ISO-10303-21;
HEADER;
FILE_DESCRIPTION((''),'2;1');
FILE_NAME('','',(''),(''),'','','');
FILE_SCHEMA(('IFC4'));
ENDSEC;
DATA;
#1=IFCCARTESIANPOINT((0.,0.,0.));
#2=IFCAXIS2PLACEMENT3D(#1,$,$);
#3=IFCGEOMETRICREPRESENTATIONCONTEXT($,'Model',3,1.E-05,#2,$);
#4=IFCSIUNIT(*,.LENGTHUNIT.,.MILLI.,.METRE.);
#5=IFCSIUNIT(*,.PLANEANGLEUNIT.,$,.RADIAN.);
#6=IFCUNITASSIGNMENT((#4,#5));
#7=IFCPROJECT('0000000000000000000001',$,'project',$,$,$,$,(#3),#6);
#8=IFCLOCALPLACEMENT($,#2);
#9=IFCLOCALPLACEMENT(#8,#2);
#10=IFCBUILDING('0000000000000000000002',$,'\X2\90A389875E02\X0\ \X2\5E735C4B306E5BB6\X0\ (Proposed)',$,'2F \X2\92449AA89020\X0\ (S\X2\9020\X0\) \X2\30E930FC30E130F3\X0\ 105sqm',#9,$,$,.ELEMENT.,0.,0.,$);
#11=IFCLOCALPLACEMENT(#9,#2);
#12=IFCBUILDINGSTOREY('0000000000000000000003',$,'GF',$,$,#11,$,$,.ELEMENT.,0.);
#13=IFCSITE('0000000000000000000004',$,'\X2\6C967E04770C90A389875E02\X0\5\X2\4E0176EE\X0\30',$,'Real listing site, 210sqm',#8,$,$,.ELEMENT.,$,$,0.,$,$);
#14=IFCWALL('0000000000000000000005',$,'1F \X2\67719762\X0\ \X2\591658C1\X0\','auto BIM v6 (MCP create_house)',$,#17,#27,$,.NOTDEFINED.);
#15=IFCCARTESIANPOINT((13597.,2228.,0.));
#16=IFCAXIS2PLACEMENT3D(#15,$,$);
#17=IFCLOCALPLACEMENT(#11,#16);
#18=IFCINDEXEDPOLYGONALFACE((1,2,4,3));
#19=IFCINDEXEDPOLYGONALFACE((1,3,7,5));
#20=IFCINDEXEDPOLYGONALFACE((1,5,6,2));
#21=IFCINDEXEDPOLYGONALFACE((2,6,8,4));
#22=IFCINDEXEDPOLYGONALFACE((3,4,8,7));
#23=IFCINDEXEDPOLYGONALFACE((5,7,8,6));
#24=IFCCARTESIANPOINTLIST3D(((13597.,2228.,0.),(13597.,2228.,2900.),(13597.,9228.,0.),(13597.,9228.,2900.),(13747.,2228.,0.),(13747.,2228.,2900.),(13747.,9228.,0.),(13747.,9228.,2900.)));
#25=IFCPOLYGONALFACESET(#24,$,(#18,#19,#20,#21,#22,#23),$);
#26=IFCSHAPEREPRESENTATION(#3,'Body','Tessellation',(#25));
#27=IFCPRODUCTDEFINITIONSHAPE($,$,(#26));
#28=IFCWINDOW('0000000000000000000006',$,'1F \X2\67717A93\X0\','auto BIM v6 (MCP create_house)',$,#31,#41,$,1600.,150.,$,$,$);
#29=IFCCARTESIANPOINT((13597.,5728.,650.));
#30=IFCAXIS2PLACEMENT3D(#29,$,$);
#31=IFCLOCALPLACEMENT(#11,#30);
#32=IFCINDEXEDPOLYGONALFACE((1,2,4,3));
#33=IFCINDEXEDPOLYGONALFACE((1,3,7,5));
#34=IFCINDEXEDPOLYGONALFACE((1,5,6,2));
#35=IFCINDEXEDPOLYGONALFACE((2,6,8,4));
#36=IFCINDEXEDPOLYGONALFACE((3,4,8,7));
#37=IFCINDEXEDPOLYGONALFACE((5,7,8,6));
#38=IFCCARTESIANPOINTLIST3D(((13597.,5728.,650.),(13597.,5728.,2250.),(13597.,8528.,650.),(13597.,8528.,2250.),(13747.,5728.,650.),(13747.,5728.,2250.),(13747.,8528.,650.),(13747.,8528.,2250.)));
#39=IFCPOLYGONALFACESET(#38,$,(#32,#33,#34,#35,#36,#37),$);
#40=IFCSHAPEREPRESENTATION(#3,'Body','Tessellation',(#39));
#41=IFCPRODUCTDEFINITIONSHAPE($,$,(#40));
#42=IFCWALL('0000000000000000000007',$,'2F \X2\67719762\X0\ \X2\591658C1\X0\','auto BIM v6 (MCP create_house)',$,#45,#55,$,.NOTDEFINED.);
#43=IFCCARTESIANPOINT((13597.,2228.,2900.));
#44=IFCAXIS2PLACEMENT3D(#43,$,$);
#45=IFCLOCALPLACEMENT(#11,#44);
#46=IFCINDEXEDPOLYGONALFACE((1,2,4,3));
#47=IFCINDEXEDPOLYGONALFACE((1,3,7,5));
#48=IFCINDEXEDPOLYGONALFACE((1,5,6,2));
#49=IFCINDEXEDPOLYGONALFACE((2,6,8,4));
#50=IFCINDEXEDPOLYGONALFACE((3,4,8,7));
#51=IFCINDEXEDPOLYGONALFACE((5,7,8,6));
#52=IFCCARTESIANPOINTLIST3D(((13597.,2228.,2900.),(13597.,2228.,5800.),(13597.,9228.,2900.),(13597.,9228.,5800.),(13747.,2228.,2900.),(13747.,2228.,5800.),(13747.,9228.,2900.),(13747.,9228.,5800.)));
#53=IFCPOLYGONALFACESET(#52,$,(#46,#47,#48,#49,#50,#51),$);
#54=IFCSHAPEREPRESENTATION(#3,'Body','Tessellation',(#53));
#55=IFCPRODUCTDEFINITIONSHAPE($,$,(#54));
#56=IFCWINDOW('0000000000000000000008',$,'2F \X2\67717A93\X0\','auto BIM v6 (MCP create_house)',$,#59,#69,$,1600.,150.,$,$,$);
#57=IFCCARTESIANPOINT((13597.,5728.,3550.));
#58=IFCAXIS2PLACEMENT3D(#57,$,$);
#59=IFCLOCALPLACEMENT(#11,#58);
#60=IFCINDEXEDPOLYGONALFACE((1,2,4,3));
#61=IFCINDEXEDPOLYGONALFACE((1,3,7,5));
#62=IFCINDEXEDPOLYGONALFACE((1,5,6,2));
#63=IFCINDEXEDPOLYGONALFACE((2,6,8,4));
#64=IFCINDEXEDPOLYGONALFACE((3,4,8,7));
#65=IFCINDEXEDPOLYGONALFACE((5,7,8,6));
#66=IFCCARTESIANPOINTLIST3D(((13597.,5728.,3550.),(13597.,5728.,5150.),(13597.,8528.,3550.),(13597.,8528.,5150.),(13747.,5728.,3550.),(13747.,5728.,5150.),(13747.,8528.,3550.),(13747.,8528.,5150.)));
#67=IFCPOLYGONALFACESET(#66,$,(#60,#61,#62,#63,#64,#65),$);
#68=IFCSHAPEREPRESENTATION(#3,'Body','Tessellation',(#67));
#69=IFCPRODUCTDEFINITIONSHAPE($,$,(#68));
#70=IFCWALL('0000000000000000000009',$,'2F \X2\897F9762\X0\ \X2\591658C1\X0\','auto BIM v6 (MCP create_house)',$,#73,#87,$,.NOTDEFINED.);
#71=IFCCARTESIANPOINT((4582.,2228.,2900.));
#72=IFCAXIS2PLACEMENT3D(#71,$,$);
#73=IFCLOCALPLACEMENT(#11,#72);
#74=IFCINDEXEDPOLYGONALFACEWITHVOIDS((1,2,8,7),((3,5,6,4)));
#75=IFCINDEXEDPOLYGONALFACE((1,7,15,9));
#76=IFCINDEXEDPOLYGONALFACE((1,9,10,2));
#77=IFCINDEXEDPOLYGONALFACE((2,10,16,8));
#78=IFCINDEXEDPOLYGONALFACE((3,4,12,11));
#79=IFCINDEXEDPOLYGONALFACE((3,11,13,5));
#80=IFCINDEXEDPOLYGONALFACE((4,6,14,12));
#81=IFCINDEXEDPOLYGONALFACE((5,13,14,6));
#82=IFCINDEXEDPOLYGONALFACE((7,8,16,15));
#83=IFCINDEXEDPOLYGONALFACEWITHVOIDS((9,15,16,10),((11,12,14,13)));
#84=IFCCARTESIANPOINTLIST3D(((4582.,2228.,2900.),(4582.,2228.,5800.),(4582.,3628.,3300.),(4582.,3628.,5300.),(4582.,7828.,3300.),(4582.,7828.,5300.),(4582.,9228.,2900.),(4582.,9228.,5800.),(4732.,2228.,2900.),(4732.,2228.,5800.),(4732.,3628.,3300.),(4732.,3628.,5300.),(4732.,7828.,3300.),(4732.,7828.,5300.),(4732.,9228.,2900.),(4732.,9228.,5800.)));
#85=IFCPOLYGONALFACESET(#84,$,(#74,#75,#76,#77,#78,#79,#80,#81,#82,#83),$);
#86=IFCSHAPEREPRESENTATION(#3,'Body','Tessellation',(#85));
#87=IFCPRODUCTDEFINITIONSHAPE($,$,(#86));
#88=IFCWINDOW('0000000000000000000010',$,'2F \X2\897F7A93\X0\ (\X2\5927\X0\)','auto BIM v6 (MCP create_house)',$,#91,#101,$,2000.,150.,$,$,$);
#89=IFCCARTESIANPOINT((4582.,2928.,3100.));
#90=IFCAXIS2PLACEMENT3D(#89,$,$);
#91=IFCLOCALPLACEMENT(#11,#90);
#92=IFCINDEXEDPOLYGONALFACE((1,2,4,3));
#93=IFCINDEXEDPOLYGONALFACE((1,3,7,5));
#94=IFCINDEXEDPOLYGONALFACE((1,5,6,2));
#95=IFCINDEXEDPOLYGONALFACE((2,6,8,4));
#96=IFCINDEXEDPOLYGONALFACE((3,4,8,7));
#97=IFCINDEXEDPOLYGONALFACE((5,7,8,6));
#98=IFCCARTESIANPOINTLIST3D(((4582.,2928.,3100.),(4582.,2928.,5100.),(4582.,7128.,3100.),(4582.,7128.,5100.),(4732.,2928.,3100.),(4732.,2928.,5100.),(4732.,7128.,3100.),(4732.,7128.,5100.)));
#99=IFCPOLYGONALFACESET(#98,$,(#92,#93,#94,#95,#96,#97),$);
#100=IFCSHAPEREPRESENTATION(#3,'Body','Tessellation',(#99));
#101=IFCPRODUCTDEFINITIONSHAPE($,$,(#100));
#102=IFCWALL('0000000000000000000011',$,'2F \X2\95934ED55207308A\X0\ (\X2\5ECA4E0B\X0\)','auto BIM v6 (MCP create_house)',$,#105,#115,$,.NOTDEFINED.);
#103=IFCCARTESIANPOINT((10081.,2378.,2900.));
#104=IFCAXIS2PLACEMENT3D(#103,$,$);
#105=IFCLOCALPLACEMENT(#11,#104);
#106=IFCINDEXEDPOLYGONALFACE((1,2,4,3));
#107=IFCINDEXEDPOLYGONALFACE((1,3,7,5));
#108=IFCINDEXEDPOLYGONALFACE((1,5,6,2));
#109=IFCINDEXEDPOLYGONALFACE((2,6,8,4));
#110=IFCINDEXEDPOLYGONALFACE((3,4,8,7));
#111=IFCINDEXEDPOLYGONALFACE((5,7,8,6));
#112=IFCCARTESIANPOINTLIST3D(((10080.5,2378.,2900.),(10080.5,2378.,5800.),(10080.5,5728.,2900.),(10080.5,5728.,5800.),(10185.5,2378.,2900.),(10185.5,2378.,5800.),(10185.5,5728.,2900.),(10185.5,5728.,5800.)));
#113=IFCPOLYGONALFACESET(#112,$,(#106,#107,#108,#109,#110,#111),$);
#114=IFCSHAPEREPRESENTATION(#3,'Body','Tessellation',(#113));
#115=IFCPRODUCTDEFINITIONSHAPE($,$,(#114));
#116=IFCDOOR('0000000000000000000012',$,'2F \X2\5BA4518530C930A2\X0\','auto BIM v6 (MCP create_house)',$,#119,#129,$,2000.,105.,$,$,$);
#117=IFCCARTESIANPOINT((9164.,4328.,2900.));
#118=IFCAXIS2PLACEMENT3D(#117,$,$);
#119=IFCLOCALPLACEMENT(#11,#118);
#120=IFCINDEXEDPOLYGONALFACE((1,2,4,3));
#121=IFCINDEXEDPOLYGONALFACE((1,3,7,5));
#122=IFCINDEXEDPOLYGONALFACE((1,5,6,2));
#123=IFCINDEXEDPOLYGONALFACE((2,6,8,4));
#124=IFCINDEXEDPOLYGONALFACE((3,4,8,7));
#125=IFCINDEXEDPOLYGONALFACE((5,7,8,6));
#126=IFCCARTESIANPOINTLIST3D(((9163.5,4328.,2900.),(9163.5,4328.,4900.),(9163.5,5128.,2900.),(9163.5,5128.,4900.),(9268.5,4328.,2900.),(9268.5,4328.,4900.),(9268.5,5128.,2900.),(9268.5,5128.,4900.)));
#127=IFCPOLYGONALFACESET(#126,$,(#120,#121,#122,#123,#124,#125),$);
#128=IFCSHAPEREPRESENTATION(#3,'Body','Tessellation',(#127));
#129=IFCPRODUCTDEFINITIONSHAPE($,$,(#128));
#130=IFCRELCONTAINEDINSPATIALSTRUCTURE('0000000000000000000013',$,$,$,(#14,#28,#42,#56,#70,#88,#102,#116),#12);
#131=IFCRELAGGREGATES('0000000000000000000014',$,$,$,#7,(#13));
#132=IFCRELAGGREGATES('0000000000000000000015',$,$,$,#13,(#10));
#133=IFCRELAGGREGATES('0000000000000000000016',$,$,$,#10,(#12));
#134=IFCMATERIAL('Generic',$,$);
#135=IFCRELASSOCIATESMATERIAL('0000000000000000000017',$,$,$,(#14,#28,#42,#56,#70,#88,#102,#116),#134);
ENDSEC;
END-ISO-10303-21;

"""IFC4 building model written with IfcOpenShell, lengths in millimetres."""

from ifc_helpers import new_model, si_unit, frame, frame_2d, origin, place, context, project, spatial, rectangle, extrude, material, element, fill, save


model = new_model("IFC4")

# Units and contexts
model_context = context("Model", 3, precision=1e-05, world=origin())
ifc_project = project(units=[si_unit("LENGTHUNIT", "METRE", prefix="MILLI"), si_unit("PLANEANGLEUNIT", "RADIAN")], contexts=[model_context])

# Site, building, storey
site_placement = place(None, origin())
site = spatial("IfcSite", under=ifc_project, at=site_placement, Name="沖縄県那覇市5丁目30", ObjectType="Real listing site, 210sqm", CompositionType="ELEMENT", RefElevation=0.0)
building_placement = place(site_placement, origin())
building = spatial("IfcBuilding", under=site, at=building_placement, Name="那覇市 平屋の家 (Proposed)", ObjectType="2F 鉄骨造 (S造) ラーメン 105sqm", CompositionType="ELEMENT", ElevationOfRefHeight=0.0, ElevationOfTerrain=0.0)
storey_placement = place(building_placement, origin())
storey = spatial("IfcBuildingStorey", under=building, at=storey_placement, Name="GF", CompositionType="ELEMENT", Elevation=0.0)

# Shared definitions
ifc_material = material(Name="Generic")

# Wall, opening, window
wall_1_placement = place(storey_placement, frame((13597.0, 2228.0, 0.0)))
wall_1 = element("IfcWall", 1, at=wall_1_placement, inside=storey, material=ifc_material, Name="1F 東面 外壁", Description="auto BIM v6 (MCP create_house)", PredefinedType="NOTDEFINED", context=model_context, shape_type="SweptSolid", body=[
    extrude(rectangle(XDim=150.0, YDim=7000.0, at=frame_2d((75.0, 3500.0))), frame((13597.0, 2228.0, 0.0)), (0.0, 0.0, 1.0), 2900.0),
])
opening_1_placement = place(storey_placement, frame((13597.0, 5728.0, 650.0)))
opening_1 = element("IfcOpeningElement", 2, at=opening_1_placement, cuts=wall_1, PredefinedType="NOTDEFINED", context=model_context, shape_type="SweptSolid", body=[
    extrude(rectangle(XDim=150.0, YDim=2800.0, at=frame_2d((75.0, 1400.0))), frame((13597.0, 5728.0, 650.0)), (0.0, 0.0, 1.0), 1600.0),
])
window_1_placement = place(storey_placement, frame((13597.0, 5728.0, 650.0)))
window_1 = element("IfcWindow", 3, at=window_1_placement, inside=storey, material=ifc_material, Name="1F 東窓", Description="auto BIM v6 (MCP create_house)", OverallHeight=1600.0, OverallWidth=150.0, context=model_context, shape_type="SweptSolid", body=[
    extrude(rectangle(XDim=150.0, YDim=2800.0, at=frame_2d((75.0, 1400.0))), frame((13597.0, 5728.0, 650.0)), (0.0, 0.0, 1.0), 1600.0),
])
fill(opening_1, window_1)

# Walls, openings, windows
wall_2_placement = place(storey_placement, frame((13597.0, 2228.0, 2900.0)))
wall_2 = element("IfcWall", 4, at=wall_2_placement, inside=storey, material=ifc_material, Name="2F 東面 外壁", Description="auto BIM v6 (MCP create_house)", PredefinedType="NOTDEFINED", context=model_context, shape_type="SweptSolid", body=[
    extrude(rectangle(XDim=150.0, YDim=7000.0, at=frame_2d((75.0, 3500.0))), frame((13597.0, 2228.0, 2900.0)), (0.0, 0.0, 1.0), 2900.0),
])
opening_2_placement = place(storey_placement, frame((13597.0, 5728.0, 3550.0)))
opening_2 = element("IfcOpeningElement", 5, at=opening_2_placement, cuts=wall_2, PredefinedType="NOTDEFINED", context=model_context, shape_type="SweptSolid", body=[
    extrude(rectangle(XDim=150.0, YDim=2800.0, at=frame_2d((75.0, 1400.0))), frame((13597.0, 5728.0, 3550.0)), (0.0, 0.0, 1.0), 1600.0),
])
window_2_placement = place(storey_placement, frame((13597.0, 5728.0, 3550.0)))
window_2 = element("IfcWindow", 6, at=window_2_placement, inside=storey, material=ifc_material, Name="2F 東窓", Description="auto BIM v6 (MCP create_house)", OverallHeight=1600.0, OverallWidth=150.0, context=model_context, shape_type="SweptSolid", body=[
    extrude(rectangle(XDim=150.0, YDim=2800.0, at=frame_2d((75.0, 1400.0))), frame((13597.0, 5728.0, 3550.0)), (0.0, 0.0, 1.0), 1600.0),
])
fill(opening_2, window_2)
wall_3_placement = place(storey_placement, frame((4582.0, 2228.0, 2900.0)))
wall_3 = element("IfcWall", 7, at=wall_3_placement, inside=storey, material=ifc_material, Name="2F 西面 外壁", Description="auto BIM v6 (MCP create_house)", PredefinedType="NOTDEFINED", context=model_context, shape_type="SweptSolid", body=[
    extrude(rectangle(XDim=150.0, YDim=7000.0, at=frame_2d((75.0, 3500.0))), frame((4582.0, 2228.0, 2900.0)), (0.0, 0.0, 1.0), 2900.0),
])
opening_3_placement = place(storey_placement, frame((4582.0, 2928.0, 3100.0)))
opening_3 = element("IfcOpeningElement", 8, at=opening_3_placement, cuts=wall_3, PredefinedType="NOTDEFINED", context=model_context, shape_type="SweptSolid", body=[
    extrude(rectangle(XDim=150.0, YDim=4200.0, at=frame_2d((75.0, 2100.0))), frame((4582.0, 2928.0, 3100.0)), (0.0, 0.0, 1.0), 2000.0),
])
window_3_placement = place(storey_placement, frame((4582.0, 2928.0, 3100.0)))
window_3 = element("IfcWindow", 9, at=window_3_placement, inside=storey, material=ifc_material, Name="2F 西窓 (大)", Description="auto BIM v6 (MCP create_house)", OverallHeight=2000.0, OverallWidth=150.0, context=model_context, shape_type="SweptSolid", body=[
    extrude(rectangle(XDim=150.0, YDim=4200.0, at=frame_2d((75.0, 2100.0))), frame((4582.0, 2928.0, 3100.0)), (0.0, 0.0, 1.0), 2000.0),
])
fill(opening_3, window_3)

# Wall
wall_4_placement = place(storey_placement, frame((10081.0, 2378.0, 2900.0)))
element("IfcWall", 10, at=wall_4_placement, inside=storey, material=ifc_material, Name="2F 間仕切り (廊下)", Description="auto BIM v6 (MCP create_house)", PredefinedType="NOTDEFINED", context=model_context, shape_type="SweptSolid", body=[
    extrude(rectangle(XDim=105.0, YDim=3350.0, at=frame_2d((52.0, 1675.0))), frame((10081.0, 2378.0, 2900.0)), (0.0, 0.0, 1.0), 2900.0),
])

# Door
door_placement = place(storey_placement, frame((9164.0, 4328.0, 2900.0)))
element("IfcDoor", 11, at=door_placement, inside=storey, material=ifc_material, Name="2F 室内ドア", Description="auto BIM v6 (MCP create_house)", OverallHeight=2000.0, OverallWidth=105.0, context=model_context, shape_type="SweptSolid", body=[
    extrude(rectangle(XDim=105.0, YDim=800.0, at=frame_2d((52.0, 400.0))), frame((9164.0, 4328.0, 2900.0)), (0.0, 0.0, 1.0), 2000.0),
])

save(model, "model.ifc")
